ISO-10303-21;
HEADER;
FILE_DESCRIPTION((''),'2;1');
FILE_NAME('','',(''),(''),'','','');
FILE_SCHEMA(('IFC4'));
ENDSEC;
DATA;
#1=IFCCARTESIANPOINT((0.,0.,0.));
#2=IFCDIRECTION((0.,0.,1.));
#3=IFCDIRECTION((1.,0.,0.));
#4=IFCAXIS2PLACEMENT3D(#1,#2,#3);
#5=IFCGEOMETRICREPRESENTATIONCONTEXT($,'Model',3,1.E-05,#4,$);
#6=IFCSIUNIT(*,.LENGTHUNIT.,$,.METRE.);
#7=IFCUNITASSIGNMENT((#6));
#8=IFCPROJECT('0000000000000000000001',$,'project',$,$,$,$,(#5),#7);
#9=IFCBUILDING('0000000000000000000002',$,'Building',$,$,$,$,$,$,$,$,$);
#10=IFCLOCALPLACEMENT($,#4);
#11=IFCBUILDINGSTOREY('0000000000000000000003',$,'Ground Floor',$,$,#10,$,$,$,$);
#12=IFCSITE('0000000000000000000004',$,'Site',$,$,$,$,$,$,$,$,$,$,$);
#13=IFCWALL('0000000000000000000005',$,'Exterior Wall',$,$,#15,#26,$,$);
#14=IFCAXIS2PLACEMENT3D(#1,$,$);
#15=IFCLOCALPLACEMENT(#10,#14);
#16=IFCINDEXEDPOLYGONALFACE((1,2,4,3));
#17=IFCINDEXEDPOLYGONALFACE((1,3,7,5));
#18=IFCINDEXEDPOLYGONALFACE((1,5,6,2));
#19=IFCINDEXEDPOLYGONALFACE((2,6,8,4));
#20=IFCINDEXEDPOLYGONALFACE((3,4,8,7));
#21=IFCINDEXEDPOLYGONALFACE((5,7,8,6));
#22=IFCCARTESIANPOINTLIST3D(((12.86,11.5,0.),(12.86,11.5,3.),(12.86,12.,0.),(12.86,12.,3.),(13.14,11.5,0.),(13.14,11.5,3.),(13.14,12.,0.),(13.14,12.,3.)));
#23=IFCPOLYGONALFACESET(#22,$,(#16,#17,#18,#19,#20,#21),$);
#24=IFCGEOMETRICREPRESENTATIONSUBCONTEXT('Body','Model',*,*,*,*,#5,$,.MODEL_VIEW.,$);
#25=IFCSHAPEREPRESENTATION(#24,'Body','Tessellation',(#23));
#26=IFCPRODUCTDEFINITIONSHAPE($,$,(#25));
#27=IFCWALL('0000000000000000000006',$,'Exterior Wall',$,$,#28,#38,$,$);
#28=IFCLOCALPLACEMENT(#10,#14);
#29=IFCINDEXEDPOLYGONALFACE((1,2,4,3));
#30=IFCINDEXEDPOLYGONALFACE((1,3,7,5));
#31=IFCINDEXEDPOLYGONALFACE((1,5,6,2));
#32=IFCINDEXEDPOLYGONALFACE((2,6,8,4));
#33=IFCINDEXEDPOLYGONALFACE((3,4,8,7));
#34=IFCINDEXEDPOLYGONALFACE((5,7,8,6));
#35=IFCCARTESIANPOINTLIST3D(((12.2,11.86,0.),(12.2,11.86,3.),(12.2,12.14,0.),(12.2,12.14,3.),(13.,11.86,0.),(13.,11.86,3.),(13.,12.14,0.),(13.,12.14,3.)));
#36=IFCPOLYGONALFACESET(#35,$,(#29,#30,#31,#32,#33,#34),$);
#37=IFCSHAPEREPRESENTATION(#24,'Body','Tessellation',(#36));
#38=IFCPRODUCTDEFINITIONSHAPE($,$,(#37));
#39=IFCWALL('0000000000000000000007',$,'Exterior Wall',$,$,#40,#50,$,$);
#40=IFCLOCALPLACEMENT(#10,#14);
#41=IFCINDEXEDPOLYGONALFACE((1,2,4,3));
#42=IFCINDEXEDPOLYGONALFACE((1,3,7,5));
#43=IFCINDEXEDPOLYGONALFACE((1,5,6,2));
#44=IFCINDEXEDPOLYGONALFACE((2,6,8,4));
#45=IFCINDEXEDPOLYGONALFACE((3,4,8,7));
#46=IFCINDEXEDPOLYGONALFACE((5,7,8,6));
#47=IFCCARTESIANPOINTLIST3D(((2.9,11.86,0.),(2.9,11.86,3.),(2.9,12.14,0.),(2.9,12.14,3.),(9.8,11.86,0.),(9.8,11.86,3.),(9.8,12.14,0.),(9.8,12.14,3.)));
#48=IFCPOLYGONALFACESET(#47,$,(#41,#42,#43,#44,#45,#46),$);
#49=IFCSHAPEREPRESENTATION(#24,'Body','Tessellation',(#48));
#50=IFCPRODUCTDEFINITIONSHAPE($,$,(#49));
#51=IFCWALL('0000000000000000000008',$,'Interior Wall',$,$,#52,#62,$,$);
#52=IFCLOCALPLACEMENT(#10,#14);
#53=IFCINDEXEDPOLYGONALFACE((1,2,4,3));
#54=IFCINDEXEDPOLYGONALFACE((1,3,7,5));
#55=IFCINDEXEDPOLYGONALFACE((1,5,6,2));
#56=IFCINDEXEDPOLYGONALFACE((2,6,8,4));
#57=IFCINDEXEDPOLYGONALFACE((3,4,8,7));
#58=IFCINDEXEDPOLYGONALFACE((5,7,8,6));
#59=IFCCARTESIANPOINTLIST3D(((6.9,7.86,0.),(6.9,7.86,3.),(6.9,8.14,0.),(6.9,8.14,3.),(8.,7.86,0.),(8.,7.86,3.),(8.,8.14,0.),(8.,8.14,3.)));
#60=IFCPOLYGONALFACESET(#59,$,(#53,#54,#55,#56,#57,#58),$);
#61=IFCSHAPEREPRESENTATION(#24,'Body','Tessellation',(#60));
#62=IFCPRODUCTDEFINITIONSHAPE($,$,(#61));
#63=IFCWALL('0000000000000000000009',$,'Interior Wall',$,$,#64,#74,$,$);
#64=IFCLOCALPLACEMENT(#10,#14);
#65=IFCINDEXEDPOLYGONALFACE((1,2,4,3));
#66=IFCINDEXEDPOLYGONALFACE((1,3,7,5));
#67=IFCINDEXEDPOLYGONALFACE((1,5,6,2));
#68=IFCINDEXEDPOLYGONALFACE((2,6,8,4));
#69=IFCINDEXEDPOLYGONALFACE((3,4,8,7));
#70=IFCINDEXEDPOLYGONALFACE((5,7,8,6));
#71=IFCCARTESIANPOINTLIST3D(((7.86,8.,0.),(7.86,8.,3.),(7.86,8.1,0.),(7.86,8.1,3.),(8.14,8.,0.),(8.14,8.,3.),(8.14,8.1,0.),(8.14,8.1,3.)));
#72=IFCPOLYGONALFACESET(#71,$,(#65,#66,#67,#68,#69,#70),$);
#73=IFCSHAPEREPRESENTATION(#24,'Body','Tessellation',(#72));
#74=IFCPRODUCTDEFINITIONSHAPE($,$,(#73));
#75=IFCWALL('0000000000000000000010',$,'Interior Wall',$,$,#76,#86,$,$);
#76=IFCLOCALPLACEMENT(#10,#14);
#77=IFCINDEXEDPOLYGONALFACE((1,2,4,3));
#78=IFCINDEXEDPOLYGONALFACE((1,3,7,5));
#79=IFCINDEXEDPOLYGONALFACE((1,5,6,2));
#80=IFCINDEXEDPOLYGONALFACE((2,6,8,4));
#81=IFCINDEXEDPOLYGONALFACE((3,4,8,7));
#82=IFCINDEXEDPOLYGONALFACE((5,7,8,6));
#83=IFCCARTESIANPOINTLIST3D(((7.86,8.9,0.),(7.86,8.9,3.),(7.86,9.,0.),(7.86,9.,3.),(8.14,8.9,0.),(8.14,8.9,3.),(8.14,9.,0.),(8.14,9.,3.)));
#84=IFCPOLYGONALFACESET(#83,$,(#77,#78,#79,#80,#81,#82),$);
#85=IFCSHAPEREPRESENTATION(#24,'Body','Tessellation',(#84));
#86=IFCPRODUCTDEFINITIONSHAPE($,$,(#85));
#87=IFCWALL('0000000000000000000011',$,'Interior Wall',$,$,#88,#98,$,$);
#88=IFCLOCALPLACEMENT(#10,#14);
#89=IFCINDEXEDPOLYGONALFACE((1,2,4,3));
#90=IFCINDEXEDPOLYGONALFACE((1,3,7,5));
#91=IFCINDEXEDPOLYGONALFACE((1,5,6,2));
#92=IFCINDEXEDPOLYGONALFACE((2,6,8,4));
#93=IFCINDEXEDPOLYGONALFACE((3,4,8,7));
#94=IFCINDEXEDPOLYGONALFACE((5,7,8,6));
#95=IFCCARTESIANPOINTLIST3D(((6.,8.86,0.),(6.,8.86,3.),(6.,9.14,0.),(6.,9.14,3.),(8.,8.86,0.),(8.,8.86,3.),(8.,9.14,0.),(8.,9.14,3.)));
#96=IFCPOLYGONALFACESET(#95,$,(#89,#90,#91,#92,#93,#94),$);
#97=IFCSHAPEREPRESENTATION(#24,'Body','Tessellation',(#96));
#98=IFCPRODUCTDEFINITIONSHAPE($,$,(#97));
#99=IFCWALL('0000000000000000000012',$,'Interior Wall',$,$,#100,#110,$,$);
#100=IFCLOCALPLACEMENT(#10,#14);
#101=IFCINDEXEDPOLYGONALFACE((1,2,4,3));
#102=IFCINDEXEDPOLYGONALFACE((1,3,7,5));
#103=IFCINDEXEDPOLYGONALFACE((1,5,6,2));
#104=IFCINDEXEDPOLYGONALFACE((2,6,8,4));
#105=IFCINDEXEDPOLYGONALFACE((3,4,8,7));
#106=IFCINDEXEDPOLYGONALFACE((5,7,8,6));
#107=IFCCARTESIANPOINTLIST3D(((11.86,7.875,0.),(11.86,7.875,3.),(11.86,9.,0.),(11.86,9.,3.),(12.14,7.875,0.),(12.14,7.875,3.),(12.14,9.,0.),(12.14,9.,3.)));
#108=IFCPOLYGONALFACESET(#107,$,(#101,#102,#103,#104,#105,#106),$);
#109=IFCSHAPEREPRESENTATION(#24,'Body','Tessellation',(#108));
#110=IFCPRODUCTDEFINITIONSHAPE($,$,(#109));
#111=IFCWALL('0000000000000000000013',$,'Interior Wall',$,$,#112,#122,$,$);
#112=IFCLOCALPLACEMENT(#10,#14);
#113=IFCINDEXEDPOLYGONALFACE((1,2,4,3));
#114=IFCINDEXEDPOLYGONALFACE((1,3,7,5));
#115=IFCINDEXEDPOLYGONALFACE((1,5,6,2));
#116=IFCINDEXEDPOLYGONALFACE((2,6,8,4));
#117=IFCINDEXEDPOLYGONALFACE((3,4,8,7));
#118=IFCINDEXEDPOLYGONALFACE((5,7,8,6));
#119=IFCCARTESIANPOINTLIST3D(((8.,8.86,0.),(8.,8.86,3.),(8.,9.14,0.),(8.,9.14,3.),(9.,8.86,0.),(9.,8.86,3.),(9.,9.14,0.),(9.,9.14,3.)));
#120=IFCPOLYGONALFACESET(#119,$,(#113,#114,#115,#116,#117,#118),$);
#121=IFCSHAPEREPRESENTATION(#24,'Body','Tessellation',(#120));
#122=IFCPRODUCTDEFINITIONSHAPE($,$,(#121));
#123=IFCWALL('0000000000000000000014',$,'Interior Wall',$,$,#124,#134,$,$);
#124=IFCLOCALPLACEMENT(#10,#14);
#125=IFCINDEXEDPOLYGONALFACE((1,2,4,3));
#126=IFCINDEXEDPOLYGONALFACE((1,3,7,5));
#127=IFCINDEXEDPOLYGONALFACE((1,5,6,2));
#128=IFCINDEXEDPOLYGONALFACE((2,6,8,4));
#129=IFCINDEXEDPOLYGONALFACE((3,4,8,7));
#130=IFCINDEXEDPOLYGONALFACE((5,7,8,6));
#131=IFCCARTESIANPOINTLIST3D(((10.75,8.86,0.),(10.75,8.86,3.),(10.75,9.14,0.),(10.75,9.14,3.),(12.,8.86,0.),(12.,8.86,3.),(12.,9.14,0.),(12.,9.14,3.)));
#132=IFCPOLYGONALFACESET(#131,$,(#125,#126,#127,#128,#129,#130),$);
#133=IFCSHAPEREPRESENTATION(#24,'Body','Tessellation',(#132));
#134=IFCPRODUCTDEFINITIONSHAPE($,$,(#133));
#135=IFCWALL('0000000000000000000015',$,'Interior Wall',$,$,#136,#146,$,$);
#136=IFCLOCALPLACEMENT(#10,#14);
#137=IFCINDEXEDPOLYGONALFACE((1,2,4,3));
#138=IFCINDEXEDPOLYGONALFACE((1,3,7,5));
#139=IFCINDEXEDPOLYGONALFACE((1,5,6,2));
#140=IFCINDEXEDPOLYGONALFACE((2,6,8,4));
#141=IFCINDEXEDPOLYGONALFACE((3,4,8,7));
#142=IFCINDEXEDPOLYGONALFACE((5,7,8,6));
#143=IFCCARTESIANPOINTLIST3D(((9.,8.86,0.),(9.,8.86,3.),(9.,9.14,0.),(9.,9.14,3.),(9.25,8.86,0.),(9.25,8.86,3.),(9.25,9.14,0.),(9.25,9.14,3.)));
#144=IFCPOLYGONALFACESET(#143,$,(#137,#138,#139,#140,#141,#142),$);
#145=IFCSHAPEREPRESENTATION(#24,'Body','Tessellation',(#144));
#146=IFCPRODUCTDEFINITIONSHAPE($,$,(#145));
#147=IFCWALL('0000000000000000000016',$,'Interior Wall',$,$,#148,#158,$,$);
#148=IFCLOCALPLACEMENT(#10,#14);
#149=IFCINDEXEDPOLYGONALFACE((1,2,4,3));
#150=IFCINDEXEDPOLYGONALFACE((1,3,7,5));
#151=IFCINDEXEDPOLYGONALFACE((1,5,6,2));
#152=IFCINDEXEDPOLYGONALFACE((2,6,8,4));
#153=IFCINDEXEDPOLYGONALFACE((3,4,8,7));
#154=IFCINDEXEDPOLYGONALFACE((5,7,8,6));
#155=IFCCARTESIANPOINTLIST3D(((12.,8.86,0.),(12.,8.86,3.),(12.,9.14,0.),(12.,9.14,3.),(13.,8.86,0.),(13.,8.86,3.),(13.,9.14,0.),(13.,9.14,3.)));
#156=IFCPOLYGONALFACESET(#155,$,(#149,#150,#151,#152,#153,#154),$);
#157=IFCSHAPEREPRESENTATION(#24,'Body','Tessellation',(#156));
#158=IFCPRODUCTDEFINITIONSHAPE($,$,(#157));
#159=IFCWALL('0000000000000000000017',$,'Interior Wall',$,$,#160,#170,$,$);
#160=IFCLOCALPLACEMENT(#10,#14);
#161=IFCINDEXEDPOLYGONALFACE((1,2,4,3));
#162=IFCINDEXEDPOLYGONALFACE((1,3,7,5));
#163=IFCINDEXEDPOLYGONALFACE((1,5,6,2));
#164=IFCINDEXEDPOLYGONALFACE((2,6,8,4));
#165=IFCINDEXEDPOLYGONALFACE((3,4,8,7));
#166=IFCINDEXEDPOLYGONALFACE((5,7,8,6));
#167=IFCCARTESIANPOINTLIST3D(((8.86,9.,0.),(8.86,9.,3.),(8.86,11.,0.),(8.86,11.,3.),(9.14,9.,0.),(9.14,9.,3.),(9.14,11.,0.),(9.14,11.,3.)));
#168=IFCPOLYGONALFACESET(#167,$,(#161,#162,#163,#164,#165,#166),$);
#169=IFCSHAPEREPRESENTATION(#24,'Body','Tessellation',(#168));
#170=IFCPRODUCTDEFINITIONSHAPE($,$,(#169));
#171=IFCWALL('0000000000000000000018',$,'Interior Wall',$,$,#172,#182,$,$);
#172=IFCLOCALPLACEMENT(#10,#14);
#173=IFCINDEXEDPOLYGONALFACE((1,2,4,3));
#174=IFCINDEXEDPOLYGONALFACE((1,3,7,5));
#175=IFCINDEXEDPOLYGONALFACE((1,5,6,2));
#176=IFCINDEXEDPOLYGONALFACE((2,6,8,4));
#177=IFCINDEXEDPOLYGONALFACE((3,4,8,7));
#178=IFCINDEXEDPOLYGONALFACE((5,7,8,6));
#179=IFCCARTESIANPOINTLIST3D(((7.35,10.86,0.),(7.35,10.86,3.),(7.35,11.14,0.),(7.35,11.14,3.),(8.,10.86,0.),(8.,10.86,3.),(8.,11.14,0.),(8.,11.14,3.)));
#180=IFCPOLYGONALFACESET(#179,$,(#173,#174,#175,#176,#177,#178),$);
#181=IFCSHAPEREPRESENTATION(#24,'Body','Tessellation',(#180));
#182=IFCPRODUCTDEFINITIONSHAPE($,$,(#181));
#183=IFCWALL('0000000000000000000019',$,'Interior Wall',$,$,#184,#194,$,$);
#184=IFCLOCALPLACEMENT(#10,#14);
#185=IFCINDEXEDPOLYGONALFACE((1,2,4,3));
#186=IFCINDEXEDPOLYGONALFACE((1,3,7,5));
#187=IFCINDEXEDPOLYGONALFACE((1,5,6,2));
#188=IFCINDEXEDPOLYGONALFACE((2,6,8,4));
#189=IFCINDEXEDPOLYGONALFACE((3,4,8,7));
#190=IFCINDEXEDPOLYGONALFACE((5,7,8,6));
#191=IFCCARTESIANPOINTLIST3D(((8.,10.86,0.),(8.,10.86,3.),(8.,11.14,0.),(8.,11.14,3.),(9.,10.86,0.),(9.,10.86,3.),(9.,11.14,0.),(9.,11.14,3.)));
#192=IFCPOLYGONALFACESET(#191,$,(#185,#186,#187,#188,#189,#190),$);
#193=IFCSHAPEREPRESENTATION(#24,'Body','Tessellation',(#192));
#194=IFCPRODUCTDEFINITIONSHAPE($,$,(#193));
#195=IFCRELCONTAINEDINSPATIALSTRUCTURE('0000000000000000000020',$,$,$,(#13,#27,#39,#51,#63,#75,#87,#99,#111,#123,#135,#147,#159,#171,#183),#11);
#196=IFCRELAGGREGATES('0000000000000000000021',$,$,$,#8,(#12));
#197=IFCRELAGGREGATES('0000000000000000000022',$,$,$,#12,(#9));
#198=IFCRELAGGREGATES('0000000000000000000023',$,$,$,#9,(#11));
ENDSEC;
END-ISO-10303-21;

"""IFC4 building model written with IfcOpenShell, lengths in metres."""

from ifc_helpers import new_model, si_unit, frame, origin_with_axes, place, context, subcontext, project, spatial, indexed_curve, outline, extrude, element, save


model = new_model("IFC4")

# Units and contexts
model_context = context("Model", 3, precision=1e-05, world=origin_with_axes())
body_context = subcontext(model_context, "Body", "Model", "MODEL_VIEW")
ifc_project = project(units=[si_unit("LENGTHUNIT", "METRE")], contexts=[model_context])

# Site, building, storey
site = spatial("IfcSite", under=ifc_project, Name="Site")
building = spatial("IfcBuilding", under=site, Name="Building")
storey_placement = place(None, origin_with_axes())
storey = spatial("IfcBuildingStorey", under=building, at=storey_placement, Name="Ground Floor")

# Walls
wall_1_placement = place(storey_placement, frame((13.0, 11.5, 0.0), z_axis=(0.0, 0.0, 1.0), x_axis=(0.0, 1.0, 0.0)))
element("IfcWall", 1, at=wall_1_placement, inside=storey, Name="Exterior Wall", context=body_context, shape_type="SweptSolid", body=[
    extrude(outline(indexed_curve([(0.0, 0.0), (0.0, 0.28), (0.5, 0.28), (0.5, 0.0), (0.0, 0.0)], self_intersect=False)), frame((0.0, -0.14, 0.0), z_axis=(0.0, 0.0, 1.0), x_axis=(1.0, 0.0, 0.0)), (0.0, 0.0, 1.0), 3.0),
])
wall_2_placement = place(storey_placement, frame((13.0, 12.0, 0.0), z_axis=(0.0, 0.0, 1.0), x_axis=(-1.0, 0.0, 0.0)))
element("IfcWall", 2, at=wall_2_placement, inside=storey, Name="Exterior Wall", context=body_context, shape_type="SweptSolid", body=[
    extrude(outline(indexed_curve([(0.0, 0.0), (0.0, 0.28), (0.8, 0.28), (0.8, 0.0), (0.0, 0.0)], self_intersect=False)), frame((0.0, -0.14, 0.0), z_axis=(0.0, 0.0, 1.0), x_axis=(1.0, 0.0, 0.0)), (0.0, 0.0, 1.0), 3.0),
])
wall_3_placement = place(storey_placement, frame((9.8, 12.0, 0.0), z_axis=(0.0, 0.0, 1.0), x_axis=(-1.0, 0.0, 0.0)))
element("IfcWall", 3, at=wall_3_placement, inside=storey, Name="Exterior Wall", context=body_context, shape_type="SweptSolid", body=[
    extrude(outline(indexed_curve([(0.0, 0.0), (0.0, 0.28), (6.9, 0.28), (6.9, 0.0), (0.0, 0.0)], self_intersect=False)), frame((0.0, -0.14, 0.0), z_axis=(0.0, 0.0, 1.0), x_axis=(1.0, 0.0, 0.0)), (0.0, 0.0, 1.0), 3.0),
])
wall_4_placement = place(storey_placement, frame((8.0, 8.0, 0.0), z_axis=(0.0, 0.0, 1.0), x_axis=(-1.0, 0.0, 0.0)))
element("IfcWall", 4, at=wall_4_placement, inside=storey, Name="Interior Wall", context=body_context, shape_type="SweptSolid", body=[
    extrude(outline(indexed_curve([(0.0, 0.0), (0.0, 0.28), (1.1, 0.28), (1.1, 0.0), (0.0, 0.0)], self_intersect=False)), frame((0.0, -0.14, 0.0), z_axis=(0.0, 0.0, 1.0), x_axis=(1.0, 0.0, 0.0)), (0.0, 0.0, 1.0), 3.0),
])
for number, where, z_axis, x_axis, name in (
    (5, (8.0, 8.0, 0.0), (0.0, 0.0, 1.0), (0.0, 1.0, 0.0), "Interior Wall"),
    (6, (8.0, 8.9, 0.0), (0.0, 0.0, 1.0), (0.0, 1.0, 0.0), "Interior Wall"),
):
    element("IfcWall", number, at=place(storey_placement, frame(where, z_axis=z_axis, x_axis=x_axis)), inside=storey, Name=name, context=body_context, shape_type="SweptSolid", body=[
        extrude(outline(indexed_curve([(0.0, 0.0), (0.0, 0.28), (0.1, 0.28), (0.1, 0.0), (0.0, 0.0)], self_intersect=False)), frame((0.0, -0.14, 0.0), z_axis=(0.0, 0.0, 1.0), x_axis=(1.0, 0.0, 0.0)), (0.0, 0.0, 1.0), 3.0),
    ])
wall_5_placement = place(storey_placement, frame((8.0, 9.0, 0.0), z_axis=(0.0, 0.0, 1.0), x_axis=(-1.0, 0.0, 0.0)))
element("IfcWall", 7, at=wall_5_placement, inside=storey, Name="Interior Wall", context=body_context, shape_type="SweptSolid", body=[
    extrude(outline(indexed_curve([(0.0, 0.0), (0.0, 0.28), (2.0, 0.28), (2.0, 0.0), (0.0, 0.0)], self_intersect=False)), frame((0.0, -0.14, 0.0), z_axis=(0.0, 0.0, 1.0), x_axis=(1.0, 0.0, 0.0)), (0.0, 0.0, 1.0), 3.0),
])
wall_6_placement = place(storey_placement, frame((12.0, 7.875, 0.0), z_axis=(0.0, 0.0, 1.0), x_axis=(0.0, 1.0, 0.0)))
element("IfcWall", 8, at=wall_6_placement, inside=storey, Name="Interior Wall", context=body_context, shape_type="SweptSolid", body=[
    extrude(outline(indexed_curve([(0.0, 0.0), (0.0, 0.28), (1.125, 0.28), (1.125, 0.0), (0.0, 0.0)], self_intersect=False)), frame((0.0, -0.14, 0.0), z_axis=(0.0, 0.0, 1.0), x_axis=(1.0, 0.0, 0.0)), (0.0, 0.0, 1.0), 3.0),
])
wall_7_placement = place(storey_placement, frame((9.0, 9.0, 0.0), z_axis=(0.0, 0.0, 1.0), x_axis=(-1.0, 0.0, 0.0)))
element("IfcWall", 9, at=wall_7_placement, inside=storey, Name="Interior Wall", context=body_context, shape_type="SweptSolid", body=[
    extrude(outline(indexed_curve([(0.0, 0.0), (0.0, 0.28), (1.0, 0.28), (1.0, 0.0), (0.0, 0.0)], self_intersect=False)), frame((0.0, -0.14, 0.0), z_axis=(0.0, 0.0, 1.0), x_axis=(1.0, 0.0, 0.0)), (0.0, 0.0, 1.0), 3.0),
])
wall_8_placement = place(storey_placement, frame((12.0, 9.0, 0.0), z_axis=(0.0, 0.0, 1.0), x_axis=(-1.0, 0.0, 0.0)))
element("IfcWall", 10, at=wall_8_placement, inside=storey, Name="Interior Wall", context=body_context, shape_type="SweptSolid", body=[
    extrude(outline(indexed_curve([(0.0, 0.0), (0.0, 0.28), (1.25, 0.28), (1.25, 0.0), (0.0, 0.0)], self_intersect=False)), frame((0.0, -0.14, 0.0), z_axis=(0.0, 0.0, 1.0), x_axis=(1.0, 0.0, 0.0)), (0.0, 0.0, 1.0), 3.0),
])
wall_9_placement = place(storey_placement, frame((9.25, 9.0, 0.0), z_axis=(0.0, 0.0, 1.0), x_axis=(-1.0, 0.0, 0.0)))
element("IfcWall", 11, at=wall_9_placement, inside=storey, Name="Interior Wall", context=body_context, shape_type="SweptSolid", body=[
    extrude(outline(indexed_curve([(0.0, 0.0), (0.0, 0.28), (0.25, 0.28), (0.25, 0.0), (0.0, 0.0)], self_intersect=False)), frame((0.0, -0.14, 0.0), z_axis=(0.0, 0.0, 1.0), x_axis=(1.0, 0.0, 0.0)), (0.0, 0.0, 1.0), 3.0),
])
wall_10_placement = place(storey_placement, frame((13.0, 9.0, 0.0), z_axis=(0.0, 0.0, 1.0), x_axis=(-1.0, 0.0, 0.0)))
element("IfcWall", 12, at=wall_10_placement, inside=storey, Name="Interior Wall", context=body_context, shape_type="SweptSolid", body=[
    extrude(outline(indexed_curve([(0.0, 0.0), (0.0, 0.28), (1.0, 0.28), (1.0, 0.0), (0.0, 0.0)], self_intersect=False)), frame((0.0, -0.14, 0.0), z_axis=(0.0, 0.0, 1.0), x_axis=(1.0, 0.0, 0.0)), (0.0, 0.0, 1.0), 3.0),
])
wall_11_placement = place(storey_placement, frame((9.0, 9.0, 0.0), z_axis=(0.0, 0.0, 1.0), x_axis=(0.0, 1.0, 0.0)))
element("IfcWall", 13, at=wall_11_placement, inside=storey, Name="Interior Wall", context=body_context, shape_type="SweptSolid", body=[
    extrude(outline(indexed_curve([(0.0, 0.0), (0.0, 0.28), (2.0, 0.28), (2.0, 0.0), (0.0, 0.0)], self_intersect=False)), frame((0.0, -0.14, 0.0), z_axis=(0.0, 0.0, 1.0), x_axis=(1.0, 0.0, 0.0)), (0.0, 0.0, 1.0), 3.0),
])
wall_12_placement = place(storey_placement, frame((8.0, 11.0, 0.0), z_axis=(0.0, 0.0, 1.0), x_axis=(-1.0, 0.0, 0.0)))
element("IfcWall", 14, at=wall_12_placement, inside=storey, Name="Interior Wall", context=body_context, shape_type="SweptSolid", body=[
    extrude(outline(indexed_curve([(0.0, 0.0), (0.0, 0.28), (0.65, 0.28), (0.65, 0.0), (0.0, 0.0)], self_intersect=False)), frame((0.0, -0.14, 0.0), z_axis=(0.0, 0.0, 1.0), x_axis=(1.0, 0.0, 0.0)), (0.0, 0.0, 1.0), 3.0),
])
wall_13_placement = place(storey_placement, frame((9.0, 11.0, 0.0), z_axis=(0.0, 0.0, 1.0), x_axis=(-1.0, 0.0, 0.0)))
element("IfcWall", 15, at=wall_13_placement, inside=storey, Name="Interior Wall", context=body_context, shape_type="SweptSolid", body=[
    extrude(outline(indexed_curve([(0.0, 0.0), (0.0, 0.28), (1.0, 0.28), (1.0, 0.0), (0.0, 0.0)], self_intersect=False)), frame((0.0, -0.14, 0.0), z_axis=(0.0, 0.0, 1.0), x_axis=(1.0, 0.0, 0.0)), (0.0, 0.0, 1.0), 3.0),
])

save(model, "model.ifc")
